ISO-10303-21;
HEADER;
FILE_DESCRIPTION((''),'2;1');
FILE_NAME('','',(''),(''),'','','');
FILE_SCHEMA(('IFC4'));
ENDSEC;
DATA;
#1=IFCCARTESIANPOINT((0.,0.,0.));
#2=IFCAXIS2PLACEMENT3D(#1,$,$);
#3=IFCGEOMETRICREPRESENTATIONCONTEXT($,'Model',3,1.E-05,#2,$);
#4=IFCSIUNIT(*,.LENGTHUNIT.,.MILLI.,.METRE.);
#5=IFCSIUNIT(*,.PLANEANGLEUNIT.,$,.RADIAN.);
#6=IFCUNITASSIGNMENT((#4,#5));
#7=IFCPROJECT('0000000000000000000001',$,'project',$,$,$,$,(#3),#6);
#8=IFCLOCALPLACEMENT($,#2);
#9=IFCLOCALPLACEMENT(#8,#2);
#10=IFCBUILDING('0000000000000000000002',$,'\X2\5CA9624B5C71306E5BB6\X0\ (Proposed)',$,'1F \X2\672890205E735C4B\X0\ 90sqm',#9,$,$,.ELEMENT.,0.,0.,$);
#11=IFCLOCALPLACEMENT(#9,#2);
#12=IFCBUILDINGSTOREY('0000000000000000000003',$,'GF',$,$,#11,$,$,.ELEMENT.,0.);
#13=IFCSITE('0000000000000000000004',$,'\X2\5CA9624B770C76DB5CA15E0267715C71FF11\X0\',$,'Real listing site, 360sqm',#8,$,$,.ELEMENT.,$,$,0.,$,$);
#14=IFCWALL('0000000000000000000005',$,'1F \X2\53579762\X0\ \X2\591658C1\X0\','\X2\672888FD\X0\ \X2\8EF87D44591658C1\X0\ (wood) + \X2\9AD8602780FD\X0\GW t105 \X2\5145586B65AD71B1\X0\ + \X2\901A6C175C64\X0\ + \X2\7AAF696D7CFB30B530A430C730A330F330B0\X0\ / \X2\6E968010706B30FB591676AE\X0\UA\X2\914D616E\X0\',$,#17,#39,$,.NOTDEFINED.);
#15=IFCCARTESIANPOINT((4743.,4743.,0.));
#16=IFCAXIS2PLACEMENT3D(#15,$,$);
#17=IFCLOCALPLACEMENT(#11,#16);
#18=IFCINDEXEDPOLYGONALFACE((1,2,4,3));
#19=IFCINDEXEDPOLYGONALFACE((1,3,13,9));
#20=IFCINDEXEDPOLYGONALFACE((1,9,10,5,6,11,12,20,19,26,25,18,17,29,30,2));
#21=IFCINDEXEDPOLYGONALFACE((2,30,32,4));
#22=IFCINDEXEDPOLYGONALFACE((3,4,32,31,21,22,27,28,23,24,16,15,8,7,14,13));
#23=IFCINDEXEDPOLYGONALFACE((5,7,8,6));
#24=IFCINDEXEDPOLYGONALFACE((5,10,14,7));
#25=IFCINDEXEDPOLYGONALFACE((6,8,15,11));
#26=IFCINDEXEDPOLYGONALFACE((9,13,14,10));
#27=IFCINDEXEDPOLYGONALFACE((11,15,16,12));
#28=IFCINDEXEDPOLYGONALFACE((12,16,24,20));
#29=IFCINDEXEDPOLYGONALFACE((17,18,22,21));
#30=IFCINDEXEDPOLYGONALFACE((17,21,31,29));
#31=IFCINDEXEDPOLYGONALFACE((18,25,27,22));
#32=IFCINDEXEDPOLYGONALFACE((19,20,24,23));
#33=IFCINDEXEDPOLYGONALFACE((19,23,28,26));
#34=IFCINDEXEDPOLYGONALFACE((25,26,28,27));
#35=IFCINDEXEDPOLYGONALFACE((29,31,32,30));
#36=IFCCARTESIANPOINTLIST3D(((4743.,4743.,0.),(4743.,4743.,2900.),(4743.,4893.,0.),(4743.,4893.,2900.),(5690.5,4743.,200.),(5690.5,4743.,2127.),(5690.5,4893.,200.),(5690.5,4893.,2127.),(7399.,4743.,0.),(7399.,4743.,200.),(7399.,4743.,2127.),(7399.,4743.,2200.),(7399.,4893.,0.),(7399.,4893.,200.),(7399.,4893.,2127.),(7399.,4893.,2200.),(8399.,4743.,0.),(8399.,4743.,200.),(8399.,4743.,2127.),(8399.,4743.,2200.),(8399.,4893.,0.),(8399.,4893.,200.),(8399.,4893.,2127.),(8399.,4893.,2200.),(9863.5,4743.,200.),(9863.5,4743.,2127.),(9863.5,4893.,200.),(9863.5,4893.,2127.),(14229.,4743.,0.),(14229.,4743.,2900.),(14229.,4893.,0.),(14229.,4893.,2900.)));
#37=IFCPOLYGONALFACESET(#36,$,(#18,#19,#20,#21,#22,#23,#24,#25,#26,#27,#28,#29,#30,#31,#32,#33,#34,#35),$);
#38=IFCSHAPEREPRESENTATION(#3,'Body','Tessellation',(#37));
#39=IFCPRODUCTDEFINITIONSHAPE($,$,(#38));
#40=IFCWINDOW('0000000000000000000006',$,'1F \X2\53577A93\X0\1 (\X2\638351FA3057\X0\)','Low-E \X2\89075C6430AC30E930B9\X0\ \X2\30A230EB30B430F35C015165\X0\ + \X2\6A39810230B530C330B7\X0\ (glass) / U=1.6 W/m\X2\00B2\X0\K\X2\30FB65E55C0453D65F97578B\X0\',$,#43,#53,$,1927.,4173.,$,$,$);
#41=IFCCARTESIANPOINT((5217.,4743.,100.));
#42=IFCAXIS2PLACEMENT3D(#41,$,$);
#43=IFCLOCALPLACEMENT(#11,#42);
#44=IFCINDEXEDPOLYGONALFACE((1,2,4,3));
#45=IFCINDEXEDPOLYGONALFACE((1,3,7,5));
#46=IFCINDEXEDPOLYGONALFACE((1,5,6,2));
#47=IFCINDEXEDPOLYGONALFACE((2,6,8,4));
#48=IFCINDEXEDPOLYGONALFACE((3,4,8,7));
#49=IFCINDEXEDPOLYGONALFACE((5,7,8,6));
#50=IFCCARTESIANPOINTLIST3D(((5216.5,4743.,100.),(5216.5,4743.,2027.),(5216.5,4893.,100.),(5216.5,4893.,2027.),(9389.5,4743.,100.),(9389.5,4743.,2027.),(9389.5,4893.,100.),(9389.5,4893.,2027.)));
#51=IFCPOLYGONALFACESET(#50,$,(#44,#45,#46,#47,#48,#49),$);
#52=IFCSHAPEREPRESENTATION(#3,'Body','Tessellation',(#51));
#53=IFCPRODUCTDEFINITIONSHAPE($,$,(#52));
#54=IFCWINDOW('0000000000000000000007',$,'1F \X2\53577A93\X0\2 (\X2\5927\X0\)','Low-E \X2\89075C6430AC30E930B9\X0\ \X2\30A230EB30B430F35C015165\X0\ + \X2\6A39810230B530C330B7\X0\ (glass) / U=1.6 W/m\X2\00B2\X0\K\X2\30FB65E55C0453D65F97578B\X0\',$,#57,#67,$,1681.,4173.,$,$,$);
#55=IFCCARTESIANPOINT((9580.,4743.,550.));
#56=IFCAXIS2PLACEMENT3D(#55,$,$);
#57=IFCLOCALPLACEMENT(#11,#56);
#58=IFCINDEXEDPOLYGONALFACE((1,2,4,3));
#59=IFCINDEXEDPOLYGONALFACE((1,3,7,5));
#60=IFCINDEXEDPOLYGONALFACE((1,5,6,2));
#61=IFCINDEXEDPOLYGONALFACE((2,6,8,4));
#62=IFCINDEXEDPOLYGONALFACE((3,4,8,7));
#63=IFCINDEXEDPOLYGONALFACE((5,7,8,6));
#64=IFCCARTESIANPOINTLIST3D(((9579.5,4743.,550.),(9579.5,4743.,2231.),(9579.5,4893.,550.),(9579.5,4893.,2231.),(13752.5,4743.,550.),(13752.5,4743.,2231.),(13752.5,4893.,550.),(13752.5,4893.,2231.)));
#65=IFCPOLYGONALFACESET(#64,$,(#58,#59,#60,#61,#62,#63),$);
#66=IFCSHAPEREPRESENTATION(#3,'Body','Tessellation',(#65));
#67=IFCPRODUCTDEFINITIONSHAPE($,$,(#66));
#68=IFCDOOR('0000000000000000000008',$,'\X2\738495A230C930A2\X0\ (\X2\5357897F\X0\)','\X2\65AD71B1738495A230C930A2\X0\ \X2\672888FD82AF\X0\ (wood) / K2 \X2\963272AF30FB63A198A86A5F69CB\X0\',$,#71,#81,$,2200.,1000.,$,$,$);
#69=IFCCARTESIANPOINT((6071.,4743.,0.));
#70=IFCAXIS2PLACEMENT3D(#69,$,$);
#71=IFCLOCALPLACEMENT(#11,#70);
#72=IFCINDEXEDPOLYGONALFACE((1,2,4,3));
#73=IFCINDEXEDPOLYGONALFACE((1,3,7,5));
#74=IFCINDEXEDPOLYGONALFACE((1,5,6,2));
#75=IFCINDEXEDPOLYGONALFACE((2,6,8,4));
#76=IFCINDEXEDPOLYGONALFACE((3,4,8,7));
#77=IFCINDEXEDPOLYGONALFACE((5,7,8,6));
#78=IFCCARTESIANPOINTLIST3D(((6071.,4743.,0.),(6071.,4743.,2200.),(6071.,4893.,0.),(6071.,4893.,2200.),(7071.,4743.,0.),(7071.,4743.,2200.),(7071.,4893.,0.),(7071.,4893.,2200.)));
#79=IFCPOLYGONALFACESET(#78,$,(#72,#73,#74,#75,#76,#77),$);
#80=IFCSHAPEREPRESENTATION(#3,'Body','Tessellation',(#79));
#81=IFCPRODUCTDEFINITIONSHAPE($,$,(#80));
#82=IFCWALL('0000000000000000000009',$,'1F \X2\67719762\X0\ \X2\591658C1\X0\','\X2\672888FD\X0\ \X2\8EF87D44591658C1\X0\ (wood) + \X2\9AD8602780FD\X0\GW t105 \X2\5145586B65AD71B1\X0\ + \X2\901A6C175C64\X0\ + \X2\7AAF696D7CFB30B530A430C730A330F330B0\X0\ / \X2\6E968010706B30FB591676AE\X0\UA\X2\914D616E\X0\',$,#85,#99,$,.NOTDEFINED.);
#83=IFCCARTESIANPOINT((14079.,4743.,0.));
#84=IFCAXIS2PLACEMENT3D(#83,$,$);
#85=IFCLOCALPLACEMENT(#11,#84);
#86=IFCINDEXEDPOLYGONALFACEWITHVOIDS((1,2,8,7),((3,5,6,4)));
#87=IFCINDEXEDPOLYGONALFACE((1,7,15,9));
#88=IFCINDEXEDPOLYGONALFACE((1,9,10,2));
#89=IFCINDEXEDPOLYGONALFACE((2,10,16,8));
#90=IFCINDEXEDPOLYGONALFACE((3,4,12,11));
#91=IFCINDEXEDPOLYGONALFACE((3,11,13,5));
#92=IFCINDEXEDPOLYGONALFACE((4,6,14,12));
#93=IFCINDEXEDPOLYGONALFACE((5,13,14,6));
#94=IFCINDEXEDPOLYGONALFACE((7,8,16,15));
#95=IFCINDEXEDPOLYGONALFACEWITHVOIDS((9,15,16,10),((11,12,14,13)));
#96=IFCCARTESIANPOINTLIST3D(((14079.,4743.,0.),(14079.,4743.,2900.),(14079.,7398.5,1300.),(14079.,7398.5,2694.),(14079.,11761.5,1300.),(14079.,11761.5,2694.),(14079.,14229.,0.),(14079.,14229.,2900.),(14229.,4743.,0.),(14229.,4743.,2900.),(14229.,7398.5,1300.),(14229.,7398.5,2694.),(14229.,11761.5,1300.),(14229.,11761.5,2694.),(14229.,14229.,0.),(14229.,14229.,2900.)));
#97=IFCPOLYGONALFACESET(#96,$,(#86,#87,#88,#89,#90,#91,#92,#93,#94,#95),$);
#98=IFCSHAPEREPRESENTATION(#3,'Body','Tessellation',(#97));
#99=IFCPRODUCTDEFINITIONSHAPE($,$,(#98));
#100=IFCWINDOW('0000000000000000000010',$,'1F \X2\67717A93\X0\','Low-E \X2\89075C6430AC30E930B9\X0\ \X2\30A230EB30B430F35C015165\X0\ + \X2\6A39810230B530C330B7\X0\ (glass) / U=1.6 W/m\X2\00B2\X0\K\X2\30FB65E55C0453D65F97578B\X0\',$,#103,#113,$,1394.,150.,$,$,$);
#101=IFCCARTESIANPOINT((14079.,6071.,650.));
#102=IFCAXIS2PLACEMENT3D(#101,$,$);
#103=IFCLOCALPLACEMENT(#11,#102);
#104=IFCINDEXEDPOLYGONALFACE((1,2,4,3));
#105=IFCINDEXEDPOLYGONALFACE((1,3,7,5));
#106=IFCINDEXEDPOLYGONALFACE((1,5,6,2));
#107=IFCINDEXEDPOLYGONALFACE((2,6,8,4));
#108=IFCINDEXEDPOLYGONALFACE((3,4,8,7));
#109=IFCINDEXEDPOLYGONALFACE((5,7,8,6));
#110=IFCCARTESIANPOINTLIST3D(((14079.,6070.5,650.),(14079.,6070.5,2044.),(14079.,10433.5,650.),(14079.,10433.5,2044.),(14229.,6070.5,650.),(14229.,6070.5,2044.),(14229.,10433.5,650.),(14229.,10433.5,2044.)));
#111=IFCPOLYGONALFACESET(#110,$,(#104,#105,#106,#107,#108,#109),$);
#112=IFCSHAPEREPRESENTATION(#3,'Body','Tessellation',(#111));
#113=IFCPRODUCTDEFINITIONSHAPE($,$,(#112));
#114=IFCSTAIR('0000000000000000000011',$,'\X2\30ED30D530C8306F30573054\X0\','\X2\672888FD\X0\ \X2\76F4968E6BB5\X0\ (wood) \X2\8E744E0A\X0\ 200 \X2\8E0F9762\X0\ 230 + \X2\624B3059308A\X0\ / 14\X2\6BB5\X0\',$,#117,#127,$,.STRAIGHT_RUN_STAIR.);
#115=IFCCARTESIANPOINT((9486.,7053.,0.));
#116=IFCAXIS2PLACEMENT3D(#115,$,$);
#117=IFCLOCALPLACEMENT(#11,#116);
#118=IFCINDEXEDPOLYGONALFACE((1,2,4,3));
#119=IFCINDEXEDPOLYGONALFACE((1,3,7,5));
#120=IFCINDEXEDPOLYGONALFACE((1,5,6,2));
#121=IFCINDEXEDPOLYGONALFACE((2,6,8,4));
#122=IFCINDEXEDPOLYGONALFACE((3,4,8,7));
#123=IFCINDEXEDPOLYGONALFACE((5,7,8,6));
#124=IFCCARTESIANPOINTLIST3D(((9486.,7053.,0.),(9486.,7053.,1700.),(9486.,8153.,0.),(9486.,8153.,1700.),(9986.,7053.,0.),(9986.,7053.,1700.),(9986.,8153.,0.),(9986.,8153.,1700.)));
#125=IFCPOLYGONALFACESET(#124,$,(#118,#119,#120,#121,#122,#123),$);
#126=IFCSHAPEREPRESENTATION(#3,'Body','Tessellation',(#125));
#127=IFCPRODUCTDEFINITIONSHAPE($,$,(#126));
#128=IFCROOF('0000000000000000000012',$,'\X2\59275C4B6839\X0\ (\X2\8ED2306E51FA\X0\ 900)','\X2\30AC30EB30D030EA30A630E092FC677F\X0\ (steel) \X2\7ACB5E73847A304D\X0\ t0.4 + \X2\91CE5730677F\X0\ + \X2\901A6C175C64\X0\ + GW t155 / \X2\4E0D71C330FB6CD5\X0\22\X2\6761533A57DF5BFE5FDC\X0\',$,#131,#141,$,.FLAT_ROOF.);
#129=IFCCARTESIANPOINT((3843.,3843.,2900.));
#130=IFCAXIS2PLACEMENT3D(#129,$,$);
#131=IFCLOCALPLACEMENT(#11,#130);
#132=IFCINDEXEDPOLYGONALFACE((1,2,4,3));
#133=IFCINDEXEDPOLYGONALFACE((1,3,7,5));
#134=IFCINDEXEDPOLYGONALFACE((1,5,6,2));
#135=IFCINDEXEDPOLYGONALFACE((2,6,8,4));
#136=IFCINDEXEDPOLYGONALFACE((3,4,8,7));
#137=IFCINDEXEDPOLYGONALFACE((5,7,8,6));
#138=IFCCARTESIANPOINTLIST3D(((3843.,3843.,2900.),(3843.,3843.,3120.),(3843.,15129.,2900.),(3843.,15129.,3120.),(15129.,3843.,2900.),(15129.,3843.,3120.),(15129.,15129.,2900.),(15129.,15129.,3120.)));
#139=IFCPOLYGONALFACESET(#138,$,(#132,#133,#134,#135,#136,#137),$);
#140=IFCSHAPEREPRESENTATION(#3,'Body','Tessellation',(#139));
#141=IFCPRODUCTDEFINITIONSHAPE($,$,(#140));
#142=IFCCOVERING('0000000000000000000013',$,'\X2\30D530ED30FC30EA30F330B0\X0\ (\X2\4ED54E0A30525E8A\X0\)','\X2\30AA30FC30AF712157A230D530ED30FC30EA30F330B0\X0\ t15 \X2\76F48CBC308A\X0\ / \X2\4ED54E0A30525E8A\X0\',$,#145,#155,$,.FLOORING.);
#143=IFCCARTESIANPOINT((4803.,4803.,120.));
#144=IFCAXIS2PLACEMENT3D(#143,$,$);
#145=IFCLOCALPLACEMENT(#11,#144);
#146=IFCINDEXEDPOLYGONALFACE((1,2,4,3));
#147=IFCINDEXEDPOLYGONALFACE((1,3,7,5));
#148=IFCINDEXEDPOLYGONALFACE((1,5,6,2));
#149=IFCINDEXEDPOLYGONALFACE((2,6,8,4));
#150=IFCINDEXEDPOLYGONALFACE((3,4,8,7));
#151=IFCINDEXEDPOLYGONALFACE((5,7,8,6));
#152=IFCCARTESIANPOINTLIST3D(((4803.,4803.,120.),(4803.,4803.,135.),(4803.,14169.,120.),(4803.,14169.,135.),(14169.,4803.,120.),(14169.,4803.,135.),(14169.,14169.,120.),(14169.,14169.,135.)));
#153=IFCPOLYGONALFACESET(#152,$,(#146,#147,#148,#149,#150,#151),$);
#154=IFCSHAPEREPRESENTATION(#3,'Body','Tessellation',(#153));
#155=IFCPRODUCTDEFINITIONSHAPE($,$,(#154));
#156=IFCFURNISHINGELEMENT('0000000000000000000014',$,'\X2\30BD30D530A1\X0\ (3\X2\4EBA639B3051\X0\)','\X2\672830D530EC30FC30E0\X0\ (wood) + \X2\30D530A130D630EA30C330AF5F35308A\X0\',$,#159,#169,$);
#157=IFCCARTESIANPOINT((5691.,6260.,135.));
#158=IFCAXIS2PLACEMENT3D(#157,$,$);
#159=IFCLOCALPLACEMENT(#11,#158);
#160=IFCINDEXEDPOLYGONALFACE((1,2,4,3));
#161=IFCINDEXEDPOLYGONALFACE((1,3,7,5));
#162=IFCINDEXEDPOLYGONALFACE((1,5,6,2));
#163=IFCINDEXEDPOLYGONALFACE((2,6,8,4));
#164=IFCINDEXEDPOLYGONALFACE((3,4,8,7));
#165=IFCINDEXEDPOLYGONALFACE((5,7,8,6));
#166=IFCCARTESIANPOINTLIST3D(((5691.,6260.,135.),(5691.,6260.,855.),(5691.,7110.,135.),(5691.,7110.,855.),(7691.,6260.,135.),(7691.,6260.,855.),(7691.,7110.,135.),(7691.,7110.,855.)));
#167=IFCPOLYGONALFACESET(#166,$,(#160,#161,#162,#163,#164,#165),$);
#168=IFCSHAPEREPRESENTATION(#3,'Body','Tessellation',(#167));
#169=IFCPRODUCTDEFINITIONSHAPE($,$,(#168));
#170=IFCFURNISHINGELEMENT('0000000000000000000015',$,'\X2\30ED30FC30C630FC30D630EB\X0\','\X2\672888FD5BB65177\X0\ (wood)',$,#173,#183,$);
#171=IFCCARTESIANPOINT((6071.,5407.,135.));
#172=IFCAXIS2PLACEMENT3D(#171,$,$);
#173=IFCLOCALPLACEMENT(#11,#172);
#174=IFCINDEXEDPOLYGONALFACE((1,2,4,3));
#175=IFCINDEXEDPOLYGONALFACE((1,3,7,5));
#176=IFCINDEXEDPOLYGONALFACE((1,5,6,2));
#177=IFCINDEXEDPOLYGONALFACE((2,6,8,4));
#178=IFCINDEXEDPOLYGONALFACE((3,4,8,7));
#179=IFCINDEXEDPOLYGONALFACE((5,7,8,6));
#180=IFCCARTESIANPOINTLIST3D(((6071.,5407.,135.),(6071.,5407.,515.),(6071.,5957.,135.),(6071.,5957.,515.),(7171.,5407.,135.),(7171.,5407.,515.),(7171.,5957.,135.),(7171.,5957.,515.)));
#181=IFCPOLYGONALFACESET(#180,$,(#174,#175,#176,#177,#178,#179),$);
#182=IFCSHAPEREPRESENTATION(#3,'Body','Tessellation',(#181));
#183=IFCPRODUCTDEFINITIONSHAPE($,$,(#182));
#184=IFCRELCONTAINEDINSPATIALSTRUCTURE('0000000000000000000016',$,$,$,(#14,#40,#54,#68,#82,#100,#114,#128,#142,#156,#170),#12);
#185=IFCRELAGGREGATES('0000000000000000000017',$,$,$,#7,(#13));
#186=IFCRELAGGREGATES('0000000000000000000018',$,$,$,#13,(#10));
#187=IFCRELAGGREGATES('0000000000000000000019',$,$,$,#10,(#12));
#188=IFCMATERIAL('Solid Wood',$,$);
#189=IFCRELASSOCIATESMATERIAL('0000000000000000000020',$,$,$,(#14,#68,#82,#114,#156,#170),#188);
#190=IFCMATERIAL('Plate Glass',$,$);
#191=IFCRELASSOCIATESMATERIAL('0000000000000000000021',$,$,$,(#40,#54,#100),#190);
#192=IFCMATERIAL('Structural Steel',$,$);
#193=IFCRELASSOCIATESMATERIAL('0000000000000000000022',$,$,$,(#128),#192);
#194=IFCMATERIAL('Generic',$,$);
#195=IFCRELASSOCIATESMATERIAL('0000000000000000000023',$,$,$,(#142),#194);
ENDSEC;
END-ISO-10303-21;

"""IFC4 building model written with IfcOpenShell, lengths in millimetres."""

from ifc_helpers import new_model, si_unit, frame, frame_2d, origin, place, context, project, spatial, rectangle, extrude, material, element, fill, save


model = new_model("IFC4")

# Units and contexts
model_context = context("Model", 3, precision=1e-05, world=origin())
ifc_project = project(units=[si_unit("LENGTHUNIT", "METRE", prefix="MILLI"), si_unit("PLANEANGLEUNIT", "RADIAN")], contexts=[model_context])

# Site, building, storey
site_placement = place(None, origin())
site = spatial("IfcSite", under=ifc_project, at=site_placement, Name="岩手県盛岡市東山１", ObjectType="Real listing site, 360sqm", CompositionType="ELEMENT", RefElevation=0.0)
building_placement = place(site_placement, origin())
building = spatial("IfcBuilding", under=site, at=building_placement, Name="岩手山の家 (Proposed)", ObjectType="1F 木造平屋 90sqm", CompositionType="ELEMENT", ElevationOfRefHeight=0.0, ElevationOfTerrain=0.0)
storey_placement = place(building_placement, origin())
storey = spatial("IfcBuildingStorey", under=building, at=storey_placement, Name="GF", CompositionType="ELEMENT", Elevation=0.0)

# Shared definitions
ifc_material_1 = material(Name="Solid Wood")

# Wall, openings, windows, door
wall_1_placement = place(storey_placement, frame((4743.0, 4743.0, 0.0)))
wall_1 = element("IfcWall", 1, at=wall_1_placement, inside=storey, material=ifc_material_1, Name="1F 南面 外壁", Description="木製 軸組外壁 (wood) + 高性能GW t105 充填断熱 + 通気層 + 窯業系サイディング / 準耐火・外皮UA配慮", PredefinedType="NOTDEFINED", context=model_context, shape_type="SweptSolid", body=[
    extrude(rectangle(XDim=9486.0, YDim=150.0, at=frame_2d((4743.0, 75.0))), frame((4743.0, 4743.0, 0.0)), (0.0, 0.0, 1.0), 2900.0),
])
opening_1_placement = place(storey_placement, frame((5217.0, 4743.0, 100.0)))
opening_1 = element("IfcOpeningElement", 2, at=opening_1_placement, cuts=wall_1, PredefinedType="NOTDEFINED", context=model_context, shape_type="SweptSolid", body=[
    extrude(rectangle(XDim=4173.0, YDim=150.0, at=frame_2d((2086.0, 75.0))), frame((5217.0, 4743.0, 100.0)), (0.0, 0.0, 1.0), 1927.0),
])
opening_2_placement = place(storey_placement, frame((9580.0, 4743.0, 550.0)))
opening_2 = element("IfcOpeningElement", 3, at=opening_2_placement, cuts=wall_1, PredefinedType="NOTDEFINED", context=model_context, shape_type="SweptSolid", body=[
    extrude(rectangle(XDim=4173.0, YDim=150.0, at=frame_2d((2086.0, 75.0))), frame((9580.0, 4743.0, 550.0)), (0.0, 0.0, 1.0), 1681.0),
])
opening_3_placement = place(storey_placement, frame((6071.0, 4743.0, 0.0)))
opening_3 = element("IfcOpeningElement", 4, at=opening_3_placement, cuts=wall_1, PredefinedType="NOTDEFINED", context=model_context, shape_type="SweptSolid", body=[
    extrude(rectangle(XDim=1000.0, YDim=150.0, at=frame_2d((500.0, 75.0))), frame((6071.0, 4743.0, 0.0)), (0.0, 0.0, 1.0), 2200.0),
])
ifc_material_2 = material(Name="Plate Glass")
window_1_placement = place(storey_placement, frame((5217.0, 4743.0, 100.0)))
window_1 = element("IfcWindow", 5, at=window_1_placement, inside=storey, material=ifc_material_2, Name="1F 南窓1 (掃出し)", Description="Low-E 複層ガラス アルゴン封入 + 樹脂サッシ (glass) / U=1.6 W/m²K・日射取得型", OverallHeight=1927.0, OverallWidth=4173.0, context=model_context, shape_type="SweptSolid", body=[
    extrude(rectangle(XDim=4173.0, YDim=150.0, at=frame_2d((2086.0, 75.0))), frame((5217.0, 4743.0, 100.0)), (0.0, 0.0, 1.0), 1927.0),
])
fill(opening_1, window_1)
window_2_placement = place(storey_placement, frame((9580.0, 4743.0, 550.0)))
window_2 = element("IfcWindow", 6, at=window_2_placement, inside=storey, material=ifc_material_2, Name="1F 南窓2 (大)", Description="Low-E 複層ガラス アルゴン封入 + 樹脂サッシ (glass) / U=1.6 W/m²K・日射取得型", OverallHeight=1681.0, OverallWidth=4173.0, context=model_context, shape_type="SweptSolid", body=[
    extrude(rectangle(XDim=4173.0, YDim=150.0, at=frame_2d((2086.0, 75.0))), frame((9580.0, 4743.0, 550.0)), (0.0, 0.0, 1.0), 1681.0),
])
fill(opening_2, window_2)
door_placement = place(storey_placement, frame((6071.0, 4743.0, 0.0)))
door = element("IfcDoor", 7, at=door_placement, inside=storey, material=ifc_material_1, Name="玄関ドア (南西)", Description="断熱玄関ドア 木製芯 (wood) / K2 防犯・採風機構", OverallHeight=2200.0, OverallWidth=1000.0, context=model_context, shape_type="SweptSolid", body=[
    extrude(rectangle(XDim=1000.0, YDim=150.0, at=frame_2d((500.0, 75.0))), frame((6071.0, 4743.0, 0.0)), (0.0, 0.0, 1.0), 2200.0),
])
fill(opening_3, door)

# Wall, opening, window
wall_2_placement = place(storey_placement, frame((14079.0, 4743.0, 0.0)))
wall_2 = element("IfcWall", 8, at=wall_2_placement, inside=storey, material=ifc_material_1, Name="1F 東面 外壁", Description="木製 軸組外壁 (wood) + 高性能GW t105 充填断熱 + 通気層 + 窯業系サイディング / 準耐火・外皮UA配慮", PredefinedType="NOTDEFINED", context=model_context, shape_type="SweptSolid", body=[
    extrude(rectangle(XDim=150.0, YDim=9486.0, at=frame_2d((75.0, 4743.0))), frame((14079.0, 4743.0, 0.0)), (0.0, 0.0, 1.0), 2900.0),
])
opening_4_placement = place(storey_placement, frame((14079.0, 6071.0, 650.0)))
opening_4 = element("IfcOpeningElement", 9, at=opening_4_placement, cuts=wall_2, PredefinedType="NOTDEFINED", context=model_context, shape_type="SweptSolid", body=[
    extrude(rectangle(XDim=150.0, YDim=4363.0, at=frame_2d((75.0, 2181.0))), frame((14079.0, 6071.0, 650.0)), (0.0, 0.0, 1.0), 1394.0),
])
window_3_placement = place(storey_placement, frame((14079.0, 6071.0, 650.0)))
window_3 = element("IfcWindow", 10, at=window_3_placement, inside=storey, material=ifc_material_2, Name="1F 東窓", Description="Low-E 複層ガラス アルゴン封入 + 樹脂サッシ (glass) / U=1.6 W/m²K・日射取得型", OverallHeight=1394.0, OverallWidth=150.0, context=model_context, shape_type="SweptSolid", body=[
    extrude(rectangle(XDim=150.0, YDim=4363.0, at=frame_2d((75.0, 2181.0))), frame((14079.0, 6071.0, 650.0)), (0.0, 0.0, 1.0), 1394.0),
])
fill(opening_4, window_3)

# Stair
stair_placement = place(storey_placement, frame((9486.0, 7053.0, 0.0)))
element("IfcStair", 11, at=stair_placement, inside=storey, material=ifc_material_1, Name="ロフトはしご", Description="木製 直階段 (wood) 蹴上 200 踏面 230 + 手すり / 14段", PredefinedType="STRAIGHT_RUN_STAIR", context=model_context, shape_type="SweptSolid", body=[
    extrude(rectangle(XDim=500.0, YDim=1100.0, at=frame_2d((250.0, 550.0))), frame((9486.0, 7053.0, 0.0)), (0.0, 0.0, 1.0), 1700.0),
])

# Roof
ifc_material_3 = material(Name="Structural Steel")
roof_placement = place(storey_placement, frame((3843.0, 3843.0, 2900.0)))
element("IfcRoof", 12, at=roof_placement, inside=storey, material=ifc_material_3, Name="大屋根 (軒の出 900)", Description="ガルバリウム鋼板 (steel) 立平葺き t0.4 + 野地板 + 通気層 + GW t155 / 不燃・法22条区域対応", PredefinedType="FLAT_ROOF", context=model_context, shape_type="SweptSolid", body=[
    extrude(rectangle(XDim=11286.0, YDim=11286.0, at=frame_2d((5643.0, 5643.0))), frame((3843.0, 3843.0, 2900.0)), (0.0, 0.0, 1.0), 220.0),
])

# Covering
ifc_material_4 = material(Name="Generic")
covering_placement = place(storey_placement, frame((4803.0, 4803.0, 120.0)))
element("IfcCovering", 13, at=covering_placement, inside=storey, material=ifc_material_4, Name="フローリング (仕上げ床)", Description="オーク無垢フローリング t15 直貼り / 仕上げ床", PredefinedType="FLOORING", context=model_context, shape_type="SweptSolid", body=[
    extrude(rectangle(XDim=9366.0, YDim=9366.0, at=frame_2d((4683.0, 4683.0))), frame((4803.0, 4803.0, 120.0)), (0.0, 0.0, 1.0), 15.0),
])

# Furnishing elements
furnishing_1_placement = place(storey_placement, frame((5691.0, 6260.0, 135.0)))
element("IfcFurnishingElement", 14, at=furnishing_1_placement, inside=storey, material=ifc_material_1, Name="ソファ (3人掛け)", Description="木フレーム (wood) + ファブリック張り", context=model_context, shape_type="SweptSolid", body=[
    extrude(rectangle(XDim=2000.0, YDim=850.0, at=frame_2d((1000.0, 425.0))), frame((5691.0, 6260.0, 135.0)), (0.0, 0.0, 1.0), 720.0),
])
furnishing_2_placement = place(storey_placement, frame((6071.0, 5407.0, 135.0)))
element("IfcFurnishingElement", 15, at=furnishing_2_placement, inside=storey, material=ifc_material_1, Name="ローテーブル", Description="木製家具 (wood)", context=model_context, shape_type="SweptSolid", body=[
    extrude(rectangle(XDim=1100.0, YDim=550.0, at=frame_2d((550.0, 275.0))), frame((6071.0, 5407.0, 135.0)), (0.0, 0.0, 1.0), 380.0),
])

save(model, "model.ifc")
